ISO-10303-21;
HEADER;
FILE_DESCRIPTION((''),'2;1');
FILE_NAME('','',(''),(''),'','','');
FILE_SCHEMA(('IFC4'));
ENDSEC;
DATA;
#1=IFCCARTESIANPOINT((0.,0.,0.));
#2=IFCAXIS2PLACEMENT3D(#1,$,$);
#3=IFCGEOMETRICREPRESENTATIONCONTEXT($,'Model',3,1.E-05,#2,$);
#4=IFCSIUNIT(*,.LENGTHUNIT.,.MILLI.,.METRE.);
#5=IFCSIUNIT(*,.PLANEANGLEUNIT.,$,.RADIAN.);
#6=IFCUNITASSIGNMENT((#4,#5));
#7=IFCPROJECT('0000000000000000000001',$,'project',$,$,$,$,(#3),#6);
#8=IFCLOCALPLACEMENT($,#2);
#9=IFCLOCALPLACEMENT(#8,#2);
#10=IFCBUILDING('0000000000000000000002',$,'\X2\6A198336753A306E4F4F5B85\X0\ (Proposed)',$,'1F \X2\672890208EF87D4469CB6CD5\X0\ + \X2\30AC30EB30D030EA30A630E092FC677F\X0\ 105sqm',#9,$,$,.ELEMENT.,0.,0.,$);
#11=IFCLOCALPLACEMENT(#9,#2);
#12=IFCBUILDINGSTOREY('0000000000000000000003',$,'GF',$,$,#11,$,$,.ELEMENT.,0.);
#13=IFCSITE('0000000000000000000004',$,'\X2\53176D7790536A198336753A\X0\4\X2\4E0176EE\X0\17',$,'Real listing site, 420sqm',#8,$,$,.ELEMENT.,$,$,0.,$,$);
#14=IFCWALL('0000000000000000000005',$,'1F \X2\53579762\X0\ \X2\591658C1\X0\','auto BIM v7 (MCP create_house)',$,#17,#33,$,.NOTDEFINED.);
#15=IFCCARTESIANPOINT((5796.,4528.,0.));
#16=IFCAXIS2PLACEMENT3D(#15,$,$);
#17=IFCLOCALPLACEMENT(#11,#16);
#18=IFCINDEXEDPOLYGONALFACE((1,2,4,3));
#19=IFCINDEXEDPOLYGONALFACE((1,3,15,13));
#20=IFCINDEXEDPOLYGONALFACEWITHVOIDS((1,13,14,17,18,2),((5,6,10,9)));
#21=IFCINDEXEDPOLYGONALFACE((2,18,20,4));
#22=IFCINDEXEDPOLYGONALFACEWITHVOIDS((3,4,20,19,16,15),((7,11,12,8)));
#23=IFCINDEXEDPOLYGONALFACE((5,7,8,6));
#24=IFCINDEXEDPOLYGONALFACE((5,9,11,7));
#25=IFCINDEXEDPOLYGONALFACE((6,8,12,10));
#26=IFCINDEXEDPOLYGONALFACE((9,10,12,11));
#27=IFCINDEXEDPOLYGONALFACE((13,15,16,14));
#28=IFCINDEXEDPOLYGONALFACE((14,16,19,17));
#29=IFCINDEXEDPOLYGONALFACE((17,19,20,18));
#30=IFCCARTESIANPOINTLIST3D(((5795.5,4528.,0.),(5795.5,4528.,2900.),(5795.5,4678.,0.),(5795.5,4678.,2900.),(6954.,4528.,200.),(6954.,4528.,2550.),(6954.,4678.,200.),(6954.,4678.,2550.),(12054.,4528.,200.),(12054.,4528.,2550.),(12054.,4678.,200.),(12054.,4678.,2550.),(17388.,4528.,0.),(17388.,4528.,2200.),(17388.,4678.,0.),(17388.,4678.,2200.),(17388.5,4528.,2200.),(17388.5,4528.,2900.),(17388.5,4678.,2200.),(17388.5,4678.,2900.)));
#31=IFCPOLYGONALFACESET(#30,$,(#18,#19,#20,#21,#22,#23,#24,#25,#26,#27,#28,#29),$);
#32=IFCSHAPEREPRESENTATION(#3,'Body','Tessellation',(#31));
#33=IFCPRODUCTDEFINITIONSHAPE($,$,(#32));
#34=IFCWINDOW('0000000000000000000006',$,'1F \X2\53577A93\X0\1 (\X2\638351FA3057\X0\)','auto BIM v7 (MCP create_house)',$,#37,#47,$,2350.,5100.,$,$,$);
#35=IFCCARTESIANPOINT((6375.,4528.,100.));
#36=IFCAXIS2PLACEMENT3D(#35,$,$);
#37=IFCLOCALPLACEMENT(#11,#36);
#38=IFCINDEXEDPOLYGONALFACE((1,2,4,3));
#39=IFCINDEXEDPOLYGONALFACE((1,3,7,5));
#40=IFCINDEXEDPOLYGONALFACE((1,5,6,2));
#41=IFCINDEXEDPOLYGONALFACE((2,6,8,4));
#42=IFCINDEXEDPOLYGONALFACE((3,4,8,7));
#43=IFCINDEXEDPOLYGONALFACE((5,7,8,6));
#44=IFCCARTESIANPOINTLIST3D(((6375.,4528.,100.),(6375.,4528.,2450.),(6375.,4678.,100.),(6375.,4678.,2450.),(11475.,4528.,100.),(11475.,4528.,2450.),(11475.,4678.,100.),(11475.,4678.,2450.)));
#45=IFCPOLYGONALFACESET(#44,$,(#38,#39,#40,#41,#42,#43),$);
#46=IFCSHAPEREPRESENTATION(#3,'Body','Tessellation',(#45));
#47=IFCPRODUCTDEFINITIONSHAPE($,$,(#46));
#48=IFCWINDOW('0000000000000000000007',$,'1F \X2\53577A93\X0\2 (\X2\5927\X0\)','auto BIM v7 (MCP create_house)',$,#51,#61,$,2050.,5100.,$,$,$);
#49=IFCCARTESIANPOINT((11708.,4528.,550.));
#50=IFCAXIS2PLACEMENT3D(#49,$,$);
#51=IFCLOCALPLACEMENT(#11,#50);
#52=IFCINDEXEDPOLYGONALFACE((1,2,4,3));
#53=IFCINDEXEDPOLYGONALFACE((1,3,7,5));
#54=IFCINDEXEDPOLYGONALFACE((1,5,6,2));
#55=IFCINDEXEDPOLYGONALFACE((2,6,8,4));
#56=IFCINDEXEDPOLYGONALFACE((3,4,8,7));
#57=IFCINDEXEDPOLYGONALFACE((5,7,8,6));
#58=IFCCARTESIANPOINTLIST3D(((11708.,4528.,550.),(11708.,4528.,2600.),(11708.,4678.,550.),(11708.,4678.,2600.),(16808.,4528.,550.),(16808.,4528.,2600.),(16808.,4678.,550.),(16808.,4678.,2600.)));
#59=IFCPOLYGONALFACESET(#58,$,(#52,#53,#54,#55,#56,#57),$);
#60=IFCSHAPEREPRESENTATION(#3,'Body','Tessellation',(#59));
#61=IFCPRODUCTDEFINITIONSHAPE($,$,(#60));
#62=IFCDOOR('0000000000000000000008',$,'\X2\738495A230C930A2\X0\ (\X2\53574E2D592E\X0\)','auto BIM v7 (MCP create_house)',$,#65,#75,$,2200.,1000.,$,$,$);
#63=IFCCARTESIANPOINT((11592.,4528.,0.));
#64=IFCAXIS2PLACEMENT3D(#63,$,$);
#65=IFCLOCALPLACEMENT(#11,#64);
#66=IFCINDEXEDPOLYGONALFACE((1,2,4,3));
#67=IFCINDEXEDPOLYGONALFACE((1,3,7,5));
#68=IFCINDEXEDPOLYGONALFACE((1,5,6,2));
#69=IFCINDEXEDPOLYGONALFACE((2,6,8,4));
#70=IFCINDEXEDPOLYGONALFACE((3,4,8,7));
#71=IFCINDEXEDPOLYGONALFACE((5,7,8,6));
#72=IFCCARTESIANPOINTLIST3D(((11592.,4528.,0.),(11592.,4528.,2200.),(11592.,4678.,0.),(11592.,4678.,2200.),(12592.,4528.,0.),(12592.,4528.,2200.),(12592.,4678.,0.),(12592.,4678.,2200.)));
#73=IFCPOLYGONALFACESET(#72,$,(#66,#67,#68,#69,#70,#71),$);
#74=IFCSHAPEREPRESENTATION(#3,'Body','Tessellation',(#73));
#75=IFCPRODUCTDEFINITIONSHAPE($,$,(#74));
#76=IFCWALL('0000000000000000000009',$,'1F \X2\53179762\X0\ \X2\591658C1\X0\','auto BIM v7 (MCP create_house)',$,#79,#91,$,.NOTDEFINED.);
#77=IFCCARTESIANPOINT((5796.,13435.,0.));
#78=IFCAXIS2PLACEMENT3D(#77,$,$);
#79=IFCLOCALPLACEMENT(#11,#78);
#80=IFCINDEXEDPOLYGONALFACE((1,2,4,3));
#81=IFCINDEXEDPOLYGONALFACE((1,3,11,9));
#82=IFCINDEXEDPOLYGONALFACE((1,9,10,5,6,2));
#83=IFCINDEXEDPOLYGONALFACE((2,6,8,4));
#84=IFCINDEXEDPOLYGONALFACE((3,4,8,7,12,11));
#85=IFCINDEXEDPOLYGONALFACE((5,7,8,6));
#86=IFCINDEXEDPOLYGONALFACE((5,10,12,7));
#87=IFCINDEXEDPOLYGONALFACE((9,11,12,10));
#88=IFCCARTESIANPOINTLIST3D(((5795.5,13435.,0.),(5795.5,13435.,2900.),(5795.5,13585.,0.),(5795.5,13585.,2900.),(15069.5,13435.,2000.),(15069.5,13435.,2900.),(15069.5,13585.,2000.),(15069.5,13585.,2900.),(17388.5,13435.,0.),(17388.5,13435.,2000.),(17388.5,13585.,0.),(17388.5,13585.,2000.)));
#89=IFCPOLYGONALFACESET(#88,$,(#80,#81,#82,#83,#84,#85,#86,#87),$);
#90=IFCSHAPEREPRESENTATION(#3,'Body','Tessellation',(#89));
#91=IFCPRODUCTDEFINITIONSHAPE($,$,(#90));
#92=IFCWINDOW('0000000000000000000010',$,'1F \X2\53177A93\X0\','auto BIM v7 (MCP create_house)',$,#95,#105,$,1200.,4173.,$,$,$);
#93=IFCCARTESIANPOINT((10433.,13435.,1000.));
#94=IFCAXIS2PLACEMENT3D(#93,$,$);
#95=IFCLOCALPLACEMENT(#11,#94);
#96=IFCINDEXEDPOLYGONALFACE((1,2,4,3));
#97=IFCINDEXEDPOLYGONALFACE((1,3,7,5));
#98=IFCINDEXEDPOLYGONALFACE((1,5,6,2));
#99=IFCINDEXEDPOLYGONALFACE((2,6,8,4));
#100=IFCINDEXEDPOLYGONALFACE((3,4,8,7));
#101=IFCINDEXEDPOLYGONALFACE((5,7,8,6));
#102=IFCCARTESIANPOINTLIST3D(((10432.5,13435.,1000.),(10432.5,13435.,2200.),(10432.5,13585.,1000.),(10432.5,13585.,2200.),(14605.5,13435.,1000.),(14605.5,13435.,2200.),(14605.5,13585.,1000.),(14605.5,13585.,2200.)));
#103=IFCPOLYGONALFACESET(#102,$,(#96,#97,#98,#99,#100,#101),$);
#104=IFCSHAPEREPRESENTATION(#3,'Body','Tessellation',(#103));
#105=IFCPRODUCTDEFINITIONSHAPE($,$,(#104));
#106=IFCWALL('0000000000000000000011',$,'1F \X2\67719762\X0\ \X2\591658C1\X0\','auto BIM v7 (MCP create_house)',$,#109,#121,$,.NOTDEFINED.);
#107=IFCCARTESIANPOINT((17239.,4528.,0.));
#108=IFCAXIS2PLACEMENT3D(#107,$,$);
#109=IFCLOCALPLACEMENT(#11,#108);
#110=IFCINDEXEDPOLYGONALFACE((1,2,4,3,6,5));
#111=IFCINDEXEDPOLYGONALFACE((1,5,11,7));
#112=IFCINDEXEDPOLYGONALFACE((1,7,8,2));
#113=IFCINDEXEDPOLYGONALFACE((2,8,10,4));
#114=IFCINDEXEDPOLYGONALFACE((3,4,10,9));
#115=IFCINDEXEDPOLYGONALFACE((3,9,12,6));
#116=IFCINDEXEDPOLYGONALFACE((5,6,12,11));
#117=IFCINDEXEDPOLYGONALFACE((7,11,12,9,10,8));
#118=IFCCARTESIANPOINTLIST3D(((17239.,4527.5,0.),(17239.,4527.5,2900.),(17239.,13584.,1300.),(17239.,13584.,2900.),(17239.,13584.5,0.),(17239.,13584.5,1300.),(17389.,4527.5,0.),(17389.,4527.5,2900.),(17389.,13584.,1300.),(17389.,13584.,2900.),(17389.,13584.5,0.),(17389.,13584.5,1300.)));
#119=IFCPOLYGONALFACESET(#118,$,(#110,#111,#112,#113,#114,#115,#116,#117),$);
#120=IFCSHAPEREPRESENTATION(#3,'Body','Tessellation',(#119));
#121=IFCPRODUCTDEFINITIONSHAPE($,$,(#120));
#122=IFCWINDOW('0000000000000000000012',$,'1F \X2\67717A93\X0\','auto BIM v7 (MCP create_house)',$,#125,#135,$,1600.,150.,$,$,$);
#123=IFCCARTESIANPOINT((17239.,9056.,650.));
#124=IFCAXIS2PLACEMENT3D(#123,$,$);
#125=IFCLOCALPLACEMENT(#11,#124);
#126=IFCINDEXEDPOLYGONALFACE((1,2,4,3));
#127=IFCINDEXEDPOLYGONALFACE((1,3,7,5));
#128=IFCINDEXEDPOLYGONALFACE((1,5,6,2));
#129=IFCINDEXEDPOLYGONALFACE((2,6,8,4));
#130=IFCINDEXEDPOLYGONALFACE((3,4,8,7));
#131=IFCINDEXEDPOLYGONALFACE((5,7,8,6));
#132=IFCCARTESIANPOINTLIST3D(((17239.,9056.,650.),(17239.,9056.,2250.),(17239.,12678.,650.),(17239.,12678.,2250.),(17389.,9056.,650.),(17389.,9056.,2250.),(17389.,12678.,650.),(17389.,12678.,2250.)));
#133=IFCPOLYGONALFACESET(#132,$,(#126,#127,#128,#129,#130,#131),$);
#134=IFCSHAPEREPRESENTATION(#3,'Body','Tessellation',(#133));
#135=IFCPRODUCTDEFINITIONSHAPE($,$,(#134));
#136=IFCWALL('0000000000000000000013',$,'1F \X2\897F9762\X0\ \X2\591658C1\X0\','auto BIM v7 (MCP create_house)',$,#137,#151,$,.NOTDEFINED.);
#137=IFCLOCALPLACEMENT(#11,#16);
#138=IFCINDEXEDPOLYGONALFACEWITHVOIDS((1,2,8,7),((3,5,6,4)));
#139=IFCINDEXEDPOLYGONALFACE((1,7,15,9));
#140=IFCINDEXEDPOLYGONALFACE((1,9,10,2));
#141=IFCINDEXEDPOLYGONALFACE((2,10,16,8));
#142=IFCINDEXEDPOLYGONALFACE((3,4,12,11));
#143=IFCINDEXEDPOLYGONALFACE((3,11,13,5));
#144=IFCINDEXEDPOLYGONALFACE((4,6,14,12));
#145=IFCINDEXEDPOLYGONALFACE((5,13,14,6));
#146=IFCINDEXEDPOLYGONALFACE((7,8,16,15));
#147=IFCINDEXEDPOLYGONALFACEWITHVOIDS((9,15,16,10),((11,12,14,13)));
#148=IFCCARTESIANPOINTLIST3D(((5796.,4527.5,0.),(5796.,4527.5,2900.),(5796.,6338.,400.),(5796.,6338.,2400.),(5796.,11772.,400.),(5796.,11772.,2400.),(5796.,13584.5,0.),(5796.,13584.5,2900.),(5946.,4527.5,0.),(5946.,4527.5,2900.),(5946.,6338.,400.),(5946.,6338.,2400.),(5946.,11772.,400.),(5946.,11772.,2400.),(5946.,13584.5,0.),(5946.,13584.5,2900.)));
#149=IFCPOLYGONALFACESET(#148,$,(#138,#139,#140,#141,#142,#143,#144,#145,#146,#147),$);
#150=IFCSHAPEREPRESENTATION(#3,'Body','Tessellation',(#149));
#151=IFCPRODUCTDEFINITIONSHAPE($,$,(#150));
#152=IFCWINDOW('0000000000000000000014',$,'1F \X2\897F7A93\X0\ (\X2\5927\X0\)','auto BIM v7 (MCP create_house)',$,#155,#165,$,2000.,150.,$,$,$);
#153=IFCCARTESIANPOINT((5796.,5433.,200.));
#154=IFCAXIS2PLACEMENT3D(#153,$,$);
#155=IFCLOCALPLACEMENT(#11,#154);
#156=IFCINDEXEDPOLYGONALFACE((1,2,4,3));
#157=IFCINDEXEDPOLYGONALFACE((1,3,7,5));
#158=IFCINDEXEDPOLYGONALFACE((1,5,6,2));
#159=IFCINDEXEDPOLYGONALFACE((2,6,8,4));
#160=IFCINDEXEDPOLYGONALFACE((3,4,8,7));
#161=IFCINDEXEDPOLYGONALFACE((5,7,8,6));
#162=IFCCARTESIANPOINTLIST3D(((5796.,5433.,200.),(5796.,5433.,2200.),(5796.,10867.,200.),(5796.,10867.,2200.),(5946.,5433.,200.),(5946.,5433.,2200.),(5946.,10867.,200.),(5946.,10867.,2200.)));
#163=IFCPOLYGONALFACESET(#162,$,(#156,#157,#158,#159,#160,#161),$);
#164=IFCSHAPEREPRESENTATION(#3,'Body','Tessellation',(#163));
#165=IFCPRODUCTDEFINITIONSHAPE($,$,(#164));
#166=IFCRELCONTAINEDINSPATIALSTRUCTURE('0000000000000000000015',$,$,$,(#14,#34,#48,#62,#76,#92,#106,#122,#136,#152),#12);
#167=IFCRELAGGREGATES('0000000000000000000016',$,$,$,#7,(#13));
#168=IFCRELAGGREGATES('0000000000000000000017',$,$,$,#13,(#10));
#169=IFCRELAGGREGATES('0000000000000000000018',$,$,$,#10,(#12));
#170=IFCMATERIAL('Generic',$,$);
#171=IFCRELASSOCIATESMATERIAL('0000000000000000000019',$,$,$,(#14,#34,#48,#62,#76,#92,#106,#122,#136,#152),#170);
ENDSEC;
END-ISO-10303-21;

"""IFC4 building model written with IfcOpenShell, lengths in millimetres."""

from ifc_helpers import new_model, si_unit, frame, frame_2d, origin, place, context, project, spatial, rectangle, extrude, material, element, fill, save


model = new_model("IFC4")

# Units and contexts
model_context = context("Model", 3, precision=1e-05, world=origin())
ifc_project = project(units=[si_unit("LENGTHUNIT", "METRE", prefix="MILLI"), si_unit("PLANEANGLEUNIT", "RADIAN")], contexts=[model_context])

# Site, building, storey
site_placement = place(None, origin())
site = spatial("IfcSite", under=ifc_project, at=site_placement, Name="北海道標茶町4丁目17", ObjectType="Real listing site, 420sqm", CompositionType="ELEMENT", RefElevation=0.0)
building_placement = place(site_placement, origin())
building = spatial("IfcBuilding", under=site, at=building_placement, Name="標茶町の住宅 (Proposed)", ObjectType="1F 木造軸組構法 + ガルバリウム鋼板 105sqm", CompositionType="ELEMENT", ElevationOfRefHeight=0.0, ElevationOfTerrain=0.0)
storey_placement = place(building_placement, origin())
storey = spatial("IfcBuildingStorey", under=building, at=storey_placement, Name="GF", CompositionType="ELEMENT", Elevation=0.0)

# Shared definitions
ifc_material = material(Name="Generic")

# Wall, openings, windows, door
wall_1_placement = place(storey_placement, frame((5796.0, 4528.0, 0.0)))
wall_1 = element("IfcWall", 1, at=wall_1_placement, inside=storey, material=ifc_material, Name="1F 南面 外壁", Description="auto BIM v7 (MCP create_house)", PredefinedType="NOTDEFINED", context=model_context, shape_type="SweptSolid", body=[
    extrude(rectangle(XDim=11593.0, YDim=150.0, at=frame_2d((5796.0, 75.0))), frame((5796.0, 4528.0, 0.0)), (0.0, 0.0, 1.0), 2900.0),
])
opening_1_placement = place(storey_placement, frame((6375.0, 4528.0, 100.0)))
opening_1 = element("IfcOpeningElement", 2, at=opening_1_placement, cuts=wall_1, PredefinedType="NOTDEFINED", context=model_context, shape_type="SweptSolid", body=[
    extrude(rectangle(XDim=5100.0, YDim=150.0, at=frame_2d((2550.0, 75.0))), frame((6375.0, 4528.0, 100.0)), (0.0, 0.0, 1.0), 2350.0),
])
opening_2_placement = place(storey_placement, frame((11708.0, 4528.0, 550.0)))
opening_2 = element("IfcOpeningElement", 3, at=opening_2_placement, cuts=wall_1, PredefinedType="NOTDEFINED", context=model_context, shape_type="SweptSolid", body=[
    extrude(rectangle(XDim=5100.0, YDim=150.0, at=frame_2d((2550.0, 75.0))), frame((11708.0, 4528.0, 550.0)), (0.0, 0.0, 1.0), 2050.0),
])
opening_3_placement = place(storey_placement, frame((11592.0, 4528.0, 0.0)))
opening_3 = element("IfcOpeningElement", 4, at=opening_3_placement, cuts=wall_1, PredefinedType="NOTDEFINED", context=model_context, shape_type="SweptSolid", body=[
    extrude(rectangle(XDim=1000.0, YDim=150.0, at=frame_2d((500.0, 75.0))), frame((11592.0, 4528.0, 0.0)), (0.0, 0.0, 1.0), 2200.0),
])
window_1_placement = place(storey_placement, frame((6375.0, 4528.0, 100.0)))
window_1 = element("IfcWindow", 5, at=window_1_placement, inside=storey, material=ifc_material, Name="1F 南窓1 (掃出し)", Description="auto BIM v7 (MCP create_house)", OverallHeight=2350.0, OverallWidth=5100.0, context=model_context, shape_type="SweptSolid", body=[
    extrude(rectangle(XDim=5100.0, YDim=150.0, at=frame_2d((2550.0, 75.0))), frame((6375.0, 4528.0, 100.0)), (0.0, 0.0, 1.0), 2350.0),
])
fill(opening_1, window_1)
window_2_placement = place(storey_placement, frame((11708.0, 4528.0, 550.0)))
window_2 = element("IfcWindow", 6, at=window_2_placement, inside=storey, material=ifc_material, Name="1F 南窓2 (大)", Description="auto BIM v7 (MCP create_house)", OverallHeight=2050.0, OverallWidth=5100.0, context=model_context, shape_type="SweptSolid", body=[
    extrude(rectangle(XDim=5100.0, YDim=150.0, at=frame_2d((2550.0, 75.0))), frame((11708.0, 4528.0, 550.0)), (0.0, 0.0, 1.0), 2050.0),
])
fill(opening_2, window_2)
door_placement = place(storey_placement, frame((11592.0, 4528.0, 0.0)))
door = element("IfcDoor", 7, at=door_placement, inside=storey, material=ifc_material, Name="玄関ドア (南中央)", Description="auto BIM v7 (MCP create_house)", OverallHeight=2200.0, OverallWidth=1000.0, context=model_context, shape_type="SweptSolid", body=[
    extrude(rectangle(XDim=1000.0, YDim=150.0, at=frame_2d((500.0, 75.0))), frame((11592.0, 4528.0, 0.0)), (0.0, 0.0, 1.0), 2200.0),
])
fill(opening_3, door)

# Walls, openings, windows
wall_2_placement = place(storey_placement, frame((5796.0, 13435.0, 0.0)))
wall_2 = element("IfcWall", 8, at=wall_2_placement, inside=storey, material=ifc_material, Name="1F 北面 外壁", Description="auto BIM v7 (MCP create_house)", PredefinedType="NOTDEFINED", context=model_context, shape_type="SweptSolid", body=[
    extrude(rectangle(XDim=11593.0, YDim=150.0, at=frame_2d((5796.0, 75.0))), frame((5796.0, 13435.0, 0.0)), (0.0, 0.0, 1.0), 2900.0),
])
opening_4_placement = place(storey_placement, frame((10433.0, 13435.0, 1000.0)))
opening_4 = element("IfcOpeningElement", 9, at=opening_4_placement, cuts=wall_2, PredefinedType="NOTDEFINED", context=model_context, shape_type="SweptSolid", body=[
    extrude(rectangle(XDim=4173.0, YDim=150.0, at=frame_2d((2086.0, 75.0))), frame((10433.0, 13435.0, 1000.0)), (0.0, 0.0, 1.0), 1200.0),
])
window_3_placement = place(storey_placement, frame((10433.0, 13435.0, 1000.0)))
window_3 = element("IfcWindow", 10, at=window_3_placement, inside=storey, material=ifc_material, Name="1F 北窓", Description="auto BIM v7 (MCP create_house)", OverallHeight=1200.0, OverallWidth=4173.0, context=model_context, shape_type="SweptSolid", body=[
    extrude(rectangle(XDim=4173.0, YDim=150.0, at=frame_2d((2086.0, 75.0))), frame((10433.0, 13435.0, 1000.0)), (0.0, 0.0, 1.0), 1200.0),
])
fill(opening_4, window_3)
wall_3_placement = place(storey_placement, frame((17239.0, 4528.0, 0.0)))
wall_3 = element("IfcWall", 11, at=wall_3_placement, inside=storey, material=ifc_material, Name="1F 東面 外壁", Description="auto BIM v7 (MCP create_house)", PredefinedType="NOTDEFINED", context=model_context, shape_type="SweptSolid", body=[
    extrude(rectangle(XDim=150.0, YDim=9057.0, at=frame_2d((75.0, 4528.0))), frame((17239.0, 4528.0, 0.0)), (0.0, 0.0, 1.0), 2900.0),
])
opening_5_placement = place(storey_placement, frame((17239.0, 9056.0, 650.0)))
opening_5 = element("IfcOpeningElement", 12, at=opening_5_placement, cuts=wall_3, PredefinedType="NOTDEFINED", context=model_context, shape_type="SweptSolid", body=[
    extrude(rectangle(XDim=150.0, YDim=3622.0, at=frame_2d((75.0, 1811.0))), frame((17239.0, 9056.0, 650.0)), (0.0, 0.0, 1.0), 1600.0),
])
window_4_placement = place(storey_placement, frame((17239.0, 9056.0, 650.0)))
window_4 = element("IfcWindow", 13, at=window_4_placement, inside=storey, material=ifc_material, Name="1F 東窓", Description="auto BIM v7 (MCP create_house)", OverallHeight=1600.0, OverallWidth=150.0, context=model_context, shape_type="SweptSolid", body=[
    extrude(rectangle(XDim=150.0, YDim=3622.0, at=frame_2d((75.0, 1811.0))), frame((17239.0, 9056.0, 650.0)), (0.0, 0.0, 1.0), 1600.0),
])
fill(opening_5, window_4)
wall_4_placement = place(storey_placement, frame((5796.0, 4528.0, 0.0)))
wall_4 = element("IfcWall", 14, at=wall_4_placement, inside=storey, material=ifc_material, Name="1F 西面 外壁", Description="auto BIM v7 (MCP create_house)", PredefinedType="NOTDEFINED", context=model_context, shape_type="SweptSolid", body=[
    extrude(rectangle(XDim=150.0, YDim=9057.0, at=frame_2d((75.0, 4528.0))), frame((5796.0, 4528.0, 0.0)), (0.0, 0.0, 1.0), 2900.0),
])
opening_6_placement = place(storey_placement, frame((5796.0, 5433.0, 200.0)))
opening_6 = element("IfcOpeningElement", 15, at=opening_6_placement, cuts=wall_4, PredefinedType="NOTDEFINED", context=model_context, shape_type="SweptSolid", body=[
    extrude(rectangle(XDim=150.0, YDim=5434.0, at=frame_2d((75.0, 2717.0))), frame((5796.0, 5433.0, 200.0)), (0.0, 0.0, 1.0), 2000.0),
])
window_5_placement = place(storey_placement, frame((5796.0, 5433.0, 200.0)))
window_5 = element("IfcWindow", 16, at=window_5_placement, inside=storey, material=ifc_material, Name="1F 西窓 (大)", Description="auto BIM v7 (MCP create_house)", OverallHeight=2000.0, OverallWidth=150.0, context=model_context, shape_type="SweptSolid", body=[
    extrude(rectangle(XDim=150.0, YDim=5434.0, at=frame_2d((75.0, 2717.0))), frame((5796.0, 5433.0, 200.0)), (0.0, 0.0, 1.0), 2000.0),
])
fill(opening_6, window_5)

save(model, "model.ifc")
